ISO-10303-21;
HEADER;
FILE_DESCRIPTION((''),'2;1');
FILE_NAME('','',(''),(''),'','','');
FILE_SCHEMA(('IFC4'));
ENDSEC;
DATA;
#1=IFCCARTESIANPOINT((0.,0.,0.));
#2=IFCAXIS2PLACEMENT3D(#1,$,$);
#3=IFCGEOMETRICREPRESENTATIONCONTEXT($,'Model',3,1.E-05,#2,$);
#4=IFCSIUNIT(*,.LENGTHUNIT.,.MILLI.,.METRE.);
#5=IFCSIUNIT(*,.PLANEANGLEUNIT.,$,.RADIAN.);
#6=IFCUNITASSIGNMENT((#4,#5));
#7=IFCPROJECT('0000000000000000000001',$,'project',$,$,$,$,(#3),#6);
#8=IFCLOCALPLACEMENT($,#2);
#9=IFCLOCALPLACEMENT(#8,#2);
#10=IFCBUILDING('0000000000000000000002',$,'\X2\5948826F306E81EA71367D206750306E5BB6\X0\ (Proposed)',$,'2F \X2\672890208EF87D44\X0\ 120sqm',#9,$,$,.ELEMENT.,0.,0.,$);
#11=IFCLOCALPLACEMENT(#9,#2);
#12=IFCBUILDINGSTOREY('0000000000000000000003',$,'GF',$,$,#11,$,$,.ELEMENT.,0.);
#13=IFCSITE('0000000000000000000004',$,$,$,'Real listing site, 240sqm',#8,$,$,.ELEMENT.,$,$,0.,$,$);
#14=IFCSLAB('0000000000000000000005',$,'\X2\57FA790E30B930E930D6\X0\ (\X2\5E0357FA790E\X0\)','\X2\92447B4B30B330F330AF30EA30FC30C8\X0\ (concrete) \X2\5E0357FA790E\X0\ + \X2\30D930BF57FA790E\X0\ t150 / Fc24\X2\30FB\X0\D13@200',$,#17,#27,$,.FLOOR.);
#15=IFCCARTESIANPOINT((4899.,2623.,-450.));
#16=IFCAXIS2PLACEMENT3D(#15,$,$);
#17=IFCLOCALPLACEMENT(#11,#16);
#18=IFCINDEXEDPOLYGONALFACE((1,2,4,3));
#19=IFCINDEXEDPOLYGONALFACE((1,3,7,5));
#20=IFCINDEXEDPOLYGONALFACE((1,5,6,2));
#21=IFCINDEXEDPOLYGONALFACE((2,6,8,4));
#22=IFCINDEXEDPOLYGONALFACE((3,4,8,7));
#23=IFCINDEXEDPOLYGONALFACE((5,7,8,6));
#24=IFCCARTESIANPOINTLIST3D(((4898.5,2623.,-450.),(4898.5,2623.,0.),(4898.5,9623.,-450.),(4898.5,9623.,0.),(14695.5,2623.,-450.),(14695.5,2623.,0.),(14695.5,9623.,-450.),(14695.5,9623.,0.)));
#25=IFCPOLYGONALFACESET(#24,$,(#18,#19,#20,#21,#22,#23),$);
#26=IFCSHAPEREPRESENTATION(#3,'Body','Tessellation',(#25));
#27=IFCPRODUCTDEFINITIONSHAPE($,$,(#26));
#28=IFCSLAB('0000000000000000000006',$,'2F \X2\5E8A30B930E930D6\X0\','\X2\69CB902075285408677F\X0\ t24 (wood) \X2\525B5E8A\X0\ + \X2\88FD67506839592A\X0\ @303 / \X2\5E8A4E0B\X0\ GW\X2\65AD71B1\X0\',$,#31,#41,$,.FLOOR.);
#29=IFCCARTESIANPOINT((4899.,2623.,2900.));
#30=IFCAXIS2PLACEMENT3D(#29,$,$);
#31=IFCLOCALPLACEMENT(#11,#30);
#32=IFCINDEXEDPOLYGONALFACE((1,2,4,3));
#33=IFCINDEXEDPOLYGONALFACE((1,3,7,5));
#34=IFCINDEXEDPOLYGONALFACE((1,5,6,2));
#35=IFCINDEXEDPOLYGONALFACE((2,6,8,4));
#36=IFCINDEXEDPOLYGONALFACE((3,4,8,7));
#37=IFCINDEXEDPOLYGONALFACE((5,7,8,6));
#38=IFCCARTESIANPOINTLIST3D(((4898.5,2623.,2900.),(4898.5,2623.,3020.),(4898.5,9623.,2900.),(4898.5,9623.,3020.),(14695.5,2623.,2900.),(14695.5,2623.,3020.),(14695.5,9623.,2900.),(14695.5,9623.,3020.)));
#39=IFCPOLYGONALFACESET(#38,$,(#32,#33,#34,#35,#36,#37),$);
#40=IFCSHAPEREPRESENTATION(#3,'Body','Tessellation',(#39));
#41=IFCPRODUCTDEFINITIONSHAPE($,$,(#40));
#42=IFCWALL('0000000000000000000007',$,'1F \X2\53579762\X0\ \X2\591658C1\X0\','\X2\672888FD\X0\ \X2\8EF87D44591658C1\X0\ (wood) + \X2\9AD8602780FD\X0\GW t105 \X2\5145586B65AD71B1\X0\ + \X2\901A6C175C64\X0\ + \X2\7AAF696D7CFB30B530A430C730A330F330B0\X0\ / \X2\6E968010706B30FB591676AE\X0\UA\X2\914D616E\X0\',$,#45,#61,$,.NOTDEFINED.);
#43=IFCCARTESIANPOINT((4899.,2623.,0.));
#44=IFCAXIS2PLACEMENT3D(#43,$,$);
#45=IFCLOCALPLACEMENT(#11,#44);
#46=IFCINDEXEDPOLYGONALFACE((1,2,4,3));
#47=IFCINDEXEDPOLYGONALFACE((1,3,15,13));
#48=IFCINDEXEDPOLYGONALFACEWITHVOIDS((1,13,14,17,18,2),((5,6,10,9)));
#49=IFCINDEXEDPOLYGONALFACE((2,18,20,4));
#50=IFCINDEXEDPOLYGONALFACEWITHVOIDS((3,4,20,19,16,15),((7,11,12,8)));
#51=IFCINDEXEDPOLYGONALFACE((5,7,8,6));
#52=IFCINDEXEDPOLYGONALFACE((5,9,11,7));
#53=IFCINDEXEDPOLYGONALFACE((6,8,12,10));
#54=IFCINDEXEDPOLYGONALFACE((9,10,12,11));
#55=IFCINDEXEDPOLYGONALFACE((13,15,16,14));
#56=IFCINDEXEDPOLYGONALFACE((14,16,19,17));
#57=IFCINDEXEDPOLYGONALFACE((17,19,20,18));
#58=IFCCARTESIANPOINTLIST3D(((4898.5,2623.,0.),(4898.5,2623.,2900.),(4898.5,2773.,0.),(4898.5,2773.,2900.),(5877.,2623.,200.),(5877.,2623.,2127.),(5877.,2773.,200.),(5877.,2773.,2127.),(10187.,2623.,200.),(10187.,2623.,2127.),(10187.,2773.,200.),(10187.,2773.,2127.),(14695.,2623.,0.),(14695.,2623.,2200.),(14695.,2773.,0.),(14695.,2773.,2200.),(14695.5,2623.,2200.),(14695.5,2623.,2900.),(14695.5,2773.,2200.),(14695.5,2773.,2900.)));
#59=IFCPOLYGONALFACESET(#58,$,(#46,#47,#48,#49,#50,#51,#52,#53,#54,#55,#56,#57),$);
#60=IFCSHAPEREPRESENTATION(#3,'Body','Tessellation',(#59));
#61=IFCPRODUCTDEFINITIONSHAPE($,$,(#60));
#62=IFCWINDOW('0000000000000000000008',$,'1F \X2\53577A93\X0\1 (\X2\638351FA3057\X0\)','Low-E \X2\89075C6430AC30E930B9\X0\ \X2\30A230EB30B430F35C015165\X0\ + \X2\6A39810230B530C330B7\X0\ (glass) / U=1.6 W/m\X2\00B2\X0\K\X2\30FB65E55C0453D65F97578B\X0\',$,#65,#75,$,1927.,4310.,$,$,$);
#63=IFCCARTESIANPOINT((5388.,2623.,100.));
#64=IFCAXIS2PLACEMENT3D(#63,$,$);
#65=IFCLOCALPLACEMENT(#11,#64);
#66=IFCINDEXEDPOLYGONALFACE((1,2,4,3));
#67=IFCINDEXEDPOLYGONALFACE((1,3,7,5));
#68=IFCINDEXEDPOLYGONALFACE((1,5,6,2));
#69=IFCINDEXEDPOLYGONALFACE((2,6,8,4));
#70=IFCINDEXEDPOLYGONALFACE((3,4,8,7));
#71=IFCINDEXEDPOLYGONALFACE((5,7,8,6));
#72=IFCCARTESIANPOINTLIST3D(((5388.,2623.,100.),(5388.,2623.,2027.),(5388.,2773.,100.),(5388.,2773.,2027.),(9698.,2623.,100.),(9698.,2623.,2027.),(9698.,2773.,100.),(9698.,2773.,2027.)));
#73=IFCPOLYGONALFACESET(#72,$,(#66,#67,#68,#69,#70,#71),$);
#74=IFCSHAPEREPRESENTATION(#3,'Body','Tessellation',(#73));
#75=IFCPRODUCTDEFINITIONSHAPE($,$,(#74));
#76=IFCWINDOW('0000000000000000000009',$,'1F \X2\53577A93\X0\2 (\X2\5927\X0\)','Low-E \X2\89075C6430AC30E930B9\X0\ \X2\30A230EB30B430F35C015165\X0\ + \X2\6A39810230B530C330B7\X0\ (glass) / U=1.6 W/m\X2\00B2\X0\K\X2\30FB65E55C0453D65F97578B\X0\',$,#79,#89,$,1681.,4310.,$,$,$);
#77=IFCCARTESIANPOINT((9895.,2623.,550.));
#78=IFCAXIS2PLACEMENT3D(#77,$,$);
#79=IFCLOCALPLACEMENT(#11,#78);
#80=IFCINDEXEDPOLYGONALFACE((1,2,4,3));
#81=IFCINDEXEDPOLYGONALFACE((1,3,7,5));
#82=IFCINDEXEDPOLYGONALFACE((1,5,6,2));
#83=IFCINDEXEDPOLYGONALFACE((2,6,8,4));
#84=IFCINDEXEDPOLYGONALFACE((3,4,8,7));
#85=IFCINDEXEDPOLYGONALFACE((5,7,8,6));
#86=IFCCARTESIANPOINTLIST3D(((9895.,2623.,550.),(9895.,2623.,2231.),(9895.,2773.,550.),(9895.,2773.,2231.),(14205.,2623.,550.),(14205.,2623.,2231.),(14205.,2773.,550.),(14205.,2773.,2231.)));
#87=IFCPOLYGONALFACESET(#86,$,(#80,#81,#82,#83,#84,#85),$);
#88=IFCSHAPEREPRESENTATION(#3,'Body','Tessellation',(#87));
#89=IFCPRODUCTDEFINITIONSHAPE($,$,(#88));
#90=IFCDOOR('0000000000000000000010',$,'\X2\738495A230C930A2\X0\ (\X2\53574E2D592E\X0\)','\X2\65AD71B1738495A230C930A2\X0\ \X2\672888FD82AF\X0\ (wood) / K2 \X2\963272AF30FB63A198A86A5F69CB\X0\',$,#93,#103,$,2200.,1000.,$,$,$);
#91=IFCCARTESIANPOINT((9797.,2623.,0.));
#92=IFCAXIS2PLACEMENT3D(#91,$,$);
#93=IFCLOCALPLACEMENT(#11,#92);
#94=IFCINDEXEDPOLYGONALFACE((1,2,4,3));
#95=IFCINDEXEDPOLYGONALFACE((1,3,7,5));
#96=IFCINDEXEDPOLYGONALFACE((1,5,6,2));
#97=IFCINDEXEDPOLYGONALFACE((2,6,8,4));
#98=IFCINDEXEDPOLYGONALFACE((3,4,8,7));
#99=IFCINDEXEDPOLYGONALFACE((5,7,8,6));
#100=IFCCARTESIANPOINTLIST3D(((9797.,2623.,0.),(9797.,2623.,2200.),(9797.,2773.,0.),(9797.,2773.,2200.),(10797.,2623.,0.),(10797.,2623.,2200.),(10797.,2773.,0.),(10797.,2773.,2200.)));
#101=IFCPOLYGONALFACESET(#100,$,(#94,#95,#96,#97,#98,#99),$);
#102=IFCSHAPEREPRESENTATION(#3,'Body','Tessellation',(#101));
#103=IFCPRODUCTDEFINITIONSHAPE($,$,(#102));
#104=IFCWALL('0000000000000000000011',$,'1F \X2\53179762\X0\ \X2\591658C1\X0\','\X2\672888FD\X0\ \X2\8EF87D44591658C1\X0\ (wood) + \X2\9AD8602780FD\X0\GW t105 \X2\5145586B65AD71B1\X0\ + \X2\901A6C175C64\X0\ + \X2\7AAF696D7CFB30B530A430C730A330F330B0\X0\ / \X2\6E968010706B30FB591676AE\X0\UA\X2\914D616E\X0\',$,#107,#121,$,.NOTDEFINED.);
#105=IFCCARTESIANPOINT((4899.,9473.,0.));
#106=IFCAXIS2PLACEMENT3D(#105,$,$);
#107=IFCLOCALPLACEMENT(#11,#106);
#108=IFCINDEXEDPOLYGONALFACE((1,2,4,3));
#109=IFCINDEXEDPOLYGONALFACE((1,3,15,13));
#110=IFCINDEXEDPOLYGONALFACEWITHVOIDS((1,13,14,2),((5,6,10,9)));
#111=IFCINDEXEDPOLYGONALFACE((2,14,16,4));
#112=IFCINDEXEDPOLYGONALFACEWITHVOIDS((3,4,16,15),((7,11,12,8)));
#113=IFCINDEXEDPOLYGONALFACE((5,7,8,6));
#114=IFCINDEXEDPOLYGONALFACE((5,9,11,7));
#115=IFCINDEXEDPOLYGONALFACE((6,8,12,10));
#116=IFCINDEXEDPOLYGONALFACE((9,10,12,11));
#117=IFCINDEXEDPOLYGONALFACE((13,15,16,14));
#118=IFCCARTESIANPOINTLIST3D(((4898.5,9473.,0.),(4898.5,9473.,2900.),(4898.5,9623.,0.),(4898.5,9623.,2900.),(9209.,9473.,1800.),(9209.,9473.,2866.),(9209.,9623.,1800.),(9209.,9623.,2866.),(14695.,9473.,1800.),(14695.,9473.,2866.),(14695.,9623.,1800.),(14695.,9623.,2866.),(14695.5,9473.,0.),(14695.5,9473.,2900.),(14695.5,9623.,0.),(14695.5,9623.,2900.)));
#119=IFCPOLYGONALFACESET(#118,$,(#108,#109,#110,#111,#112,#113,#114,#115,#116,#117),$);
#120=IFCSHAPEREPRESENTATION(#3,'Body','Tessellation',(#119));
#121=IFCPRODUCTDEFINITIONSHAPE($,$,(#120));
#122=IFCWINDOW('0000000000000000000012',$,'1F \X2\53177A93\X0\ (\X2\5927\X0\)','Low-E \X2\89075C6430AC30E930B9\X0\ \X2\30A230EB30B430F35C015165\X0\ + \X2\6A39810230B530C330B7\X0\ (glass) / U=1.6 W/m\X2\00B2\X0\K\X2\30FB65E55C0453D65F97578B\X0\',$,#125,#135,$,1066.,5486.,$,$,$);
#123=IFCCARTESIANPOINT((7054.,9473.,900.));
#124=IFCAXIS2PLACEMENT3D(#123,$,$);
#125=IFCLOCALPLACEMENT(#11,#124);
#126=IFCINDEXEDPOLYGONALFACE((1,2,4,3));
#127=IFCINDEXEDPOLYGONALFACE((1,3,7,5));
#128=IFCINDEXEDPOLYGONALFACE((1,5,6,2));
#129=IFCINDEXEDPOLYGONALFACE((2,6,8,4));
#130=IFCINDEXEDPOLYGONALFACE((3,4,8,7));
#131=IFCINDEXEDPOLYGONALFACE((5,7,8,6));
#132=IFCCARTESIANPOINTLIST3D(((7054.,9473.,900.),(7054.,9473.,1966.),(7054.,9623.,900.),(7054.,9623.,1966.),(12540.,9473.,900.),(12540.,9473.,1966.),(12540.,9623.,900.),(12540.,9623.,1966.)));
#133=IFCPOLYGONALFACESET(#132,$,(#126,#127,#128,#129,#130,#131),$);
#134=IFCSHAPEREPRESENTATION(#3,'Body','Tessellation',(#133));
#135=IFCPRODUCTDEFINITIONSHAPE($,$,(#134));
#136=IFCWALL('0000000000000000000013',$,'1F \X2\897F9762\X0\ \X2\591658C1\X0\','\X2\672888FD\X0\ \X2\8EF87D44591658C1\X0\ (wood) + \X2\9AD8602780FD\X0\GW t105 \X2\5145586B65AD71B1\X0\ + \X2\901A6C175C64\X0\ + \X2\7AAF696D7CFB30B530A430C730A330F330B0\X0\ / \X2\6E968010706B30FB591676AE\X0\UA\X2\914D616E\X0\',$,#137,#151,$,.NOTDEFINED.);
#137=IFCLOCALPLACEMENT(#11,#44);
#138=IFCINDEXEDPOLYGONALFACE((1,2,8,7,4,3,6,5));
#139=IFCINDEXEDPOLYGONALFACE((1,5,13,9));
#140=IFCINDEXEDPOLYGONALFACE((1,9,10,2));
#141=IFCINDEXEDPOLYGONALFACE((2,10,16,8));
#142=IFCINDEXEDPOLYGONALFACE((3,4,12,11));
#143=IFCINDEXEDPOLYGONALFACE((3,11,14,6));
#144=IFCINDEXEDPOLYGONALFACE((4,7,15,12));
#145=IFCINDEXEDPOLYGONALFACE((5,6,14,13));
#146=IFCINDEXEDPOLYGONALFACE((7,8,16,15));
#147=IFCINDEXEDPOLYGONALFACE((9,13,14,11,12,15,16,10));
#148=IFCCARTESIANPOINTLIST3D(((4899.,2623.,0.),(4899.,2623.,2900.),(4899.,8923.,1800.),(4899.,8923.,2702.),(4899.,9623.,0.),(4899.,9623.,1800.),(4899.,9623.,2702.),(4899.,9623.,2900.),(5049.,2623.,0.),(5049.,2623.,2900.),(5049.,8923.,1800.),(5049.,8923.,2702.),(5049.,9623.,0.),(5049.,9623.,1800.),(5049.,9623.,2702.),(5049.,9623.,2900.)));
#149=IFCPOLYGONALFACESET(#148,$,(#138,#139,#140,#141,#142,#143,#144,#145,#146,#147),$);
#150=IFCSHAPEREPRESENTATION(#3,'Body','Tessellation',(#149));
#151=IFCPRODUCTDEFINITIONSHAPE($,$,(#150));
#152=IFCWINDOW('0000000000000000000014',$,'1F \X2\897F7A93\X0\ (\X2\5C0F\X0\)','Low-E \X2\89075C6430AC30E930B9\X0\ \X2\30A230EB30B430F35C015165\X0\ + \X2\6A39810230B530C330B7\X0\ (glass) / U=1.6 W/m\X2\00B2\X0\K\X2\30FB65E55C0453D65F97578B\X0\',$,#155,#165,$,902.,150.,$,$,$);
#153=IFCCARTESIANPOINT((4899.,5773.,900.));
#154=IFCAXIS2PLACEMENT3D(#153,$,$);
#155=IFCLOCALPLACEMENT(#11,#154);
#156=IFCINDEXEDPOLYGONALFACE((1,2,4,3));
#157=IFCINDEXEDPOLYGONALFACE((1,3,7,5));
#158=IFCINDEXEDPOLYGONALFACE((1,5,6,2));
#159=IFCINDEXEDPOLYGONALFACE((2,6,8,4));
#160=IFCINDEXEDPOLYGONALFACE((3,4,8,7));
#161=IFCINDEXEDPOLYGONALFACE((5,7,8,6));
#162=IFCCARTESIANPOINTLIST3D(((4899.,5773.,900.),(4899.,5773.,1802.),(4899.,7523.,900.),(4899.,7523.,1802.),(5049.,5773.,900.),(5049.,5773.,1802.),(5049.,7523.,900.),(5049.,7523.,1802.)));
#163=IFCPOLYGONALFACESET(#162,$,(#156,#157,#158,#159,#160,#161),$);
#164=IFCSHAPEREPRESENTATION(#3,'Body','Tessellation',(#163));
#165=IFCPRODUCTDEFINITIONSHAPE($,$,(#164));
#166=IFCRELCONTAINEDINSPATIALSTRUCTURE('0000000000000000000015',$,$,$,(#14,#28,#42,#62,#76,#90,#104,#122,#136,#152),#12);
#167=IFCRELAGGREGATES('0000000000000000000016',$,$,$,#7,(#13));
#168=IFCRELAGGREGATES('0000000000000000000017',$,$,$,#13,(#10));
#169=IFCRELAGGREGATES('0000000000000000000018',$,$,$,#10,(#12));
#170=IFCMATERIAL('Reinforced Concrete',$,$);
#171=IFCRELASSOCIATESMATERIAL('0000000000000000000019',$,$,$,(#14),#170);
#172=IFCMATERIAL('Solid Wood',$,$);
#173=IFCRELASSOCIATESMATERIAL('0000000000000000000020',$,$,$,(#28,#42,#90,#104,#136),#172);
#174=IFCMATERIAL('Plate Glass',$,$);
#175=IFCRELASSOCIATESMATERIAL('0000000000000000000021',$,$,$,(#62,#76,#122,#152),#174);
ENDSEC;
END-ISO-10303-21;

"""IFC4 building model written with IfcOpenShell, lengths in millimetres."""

from ifc_helpers import new_model, si_unit, frame, frame_2d, origin, place, context, project, spatial, rectangle, extrude, material, element, fill, save


model = new_model("IFC4")

# Units and contexts
model_context = context("Model", 3, precision=1e-05, world=origin())
ifc_project = project(units=[si_unit("LENGTHUNIT", "METRE", prefix="MILLI"), si_unit("PLANEANGLEUNIT", "RADIAN")], contexts=[model_context])

# Site, building, storey
site_placement = place(None, origin())
site = spatial("IfcSite", under=ifc_project, at=site_placement, ObjectType="Real listing site, 240sqm", CompositionType="ELEMENT", RefElevation=0.0)
building_placement = place(site_placement, origin())
building = spatial("IfcBuilding", under=site, at=building_placement, Name="奈良の自然素材の家 (Proposed)", ObjectType="2F 木造軸組 120sqm", CompositionType="ELEMENT", ElevationOfRefHeight=0.0, ElevationOfTerrain=0.0)
storey_placement = place(building_placement, origin())
storey = spatial("IfcBuildingStorey", under=building, at=storey_placement, Name="GF", CompositionType="ELEMENT", Elevation=0.0)

# Slabs
ifc_material_1 = material(Name="Reinforced Concrete")
slab_1_placement = place(storey_placement, frame((4899.0, 2623.0, -450.0)))
element("IfcSlab", 1, at=slab_1_placement, inside=storey, material=ifc_material_1, Name="基礎スラブ (布基礎)", Description="鉄筋コンクリート (concrete) 布基礎 + ベタ基礎 t150 / Fc24・D13@200", PredefinedType="FLOOR", context=model_context, shape_type="SweptSolid", body=[
    extrude(rectangle(XDim=9797.0, YDim=7000.0, at=frame_2d((4898.0, 3500.0))), frame((4899.0, 2623.0, -450.0)), (0.0, 0.0, 1.0), 450.0),
])
ifc_material_2 = material(Name="Solid Wood")
slab_2_placement = place(storey_placement, frame((4899.0, 2623.0, 2900.0)))
element("IfcSlab", 2, at=slab_2_placement, inside=storey, material=ifc_material_2, Name="2F 床スラブ", Description="構造用合板 t24 (wood) 剛床 + 製材根太 @303 / 床下 GW断熱", PredefinedType="FLOOR", context=model_context, shape_type="SweptSolid", body=[
    extrude(rectangle(XDim=9797.0, YDim=7000.0, at=frame_2d((4898.0, 3500.0))), frame((4899.0, 2623.0, 2900.0)), (0.0, 0.0, 1.0), 120.0),
])

# Wall, openings, windows, door
wall_1_placement = place(storey_placement, frame((4899.0, 2623.0, 0.0)))
wall_1 = element("IfcWall", 3, at=wall_1_placement, inside=storey, material=ifc_material_2, Name="1F 南面 外壁", Description="木製 軸組外壁 (wood) + 高性能GW t105 充填断熱 + 通気層 + 窯業系サイディング / 準耐火・外皮UA配慮", PredefinedType="NOTDEFINED", context=model_context, shape_type="SweptSolid", body=[
    extrude(rectangle(XDim=9797.0, YDim=150.0, at=frame_2d((4898.0, 75.0))), frame((4899.0, 2623.0, 0.0)), (0.0, 0.0, 1.0), 2900.0),
])
opening_1_placement = place(storey_placement, frame((5388.0, 2623.0, 100.0)))
opening_1 = element("IfcOpeningElement", 4, at=opening_1_placement, cuts=wall_1, PredefinedType="NOTDEFINED", context=model_context, shape_type="SweptSolid", body=[
    extrude(rectangle(XDim=4310.0, YDim=150.0, at=frame_2d((2155.0, 75.0))), frame((5388.0, 2623.0, 100.0)), (0.0, 0.0, 1.0), 1927.0),
])
opening_2_placement = place(storey_placement, frame((9895.0, 2623.0, 550.0)))
opening_2 = element("IfcOpeningElement", 5, at=opening_2_placement, cuts=wall_1, PredefinedType="NOTDEFINED", context=model_context, shape_type="SweptSolid", body=[
    extrude(rectangle(XDim=4310.0, YDim=150.0, at=frame_2d((2155.0, 75.0))), frame((9895.0, 2623.0, 550.0)), (0.0, 0.0, 1.0), 1681.0),
])
opening_3_placement = place(storey_placement, frame((9797.0, 2623.0, 0.0)))
opening_3 = element("IfcOpeningElement", 6, at=opening_3_placement, cuts=wall_1, PredefinedType="NOTDEFINED", context=model_context, shape_type="SweptSolid", body=[
    extrude(rectangle(XDim=1000.0, YDim=150.0, at=frame_2d((500.0, 75.0))), frame((9797.0, 2623.0, 0.0)), (0.0, 0.0, 1.0), 2200.0),
])
ifc_material_3 = material(Name="Plate Glass")
window_1_placement = place(storey_placement, frame((5388.0, 2623.0, 100.0)))
window_1 = element("IfcWindow", 7, at=window_1_placement, inside=storey, material=ifc_material_3, Name="1F 南窓1 (掃出し)", Description="Low-E 複層ガラス アルゴン封入 + 樹脂サッシ (glass) / U=1.6 W/m²K・日射取得型", OverallHeight=1927.0, OverallWidth=4310.0, context=model_context, shape_type="SweptSolid", body=[
    extrude(rectangle(XDim=4310.0, YDim=150.0, at=frame_2d((2155.0, 75.0))), frame((5388.0, 2623.0, 100.0)), (0.0, 0.0, 1.0), 1927.0),
])
fill(opening_1, window_1)
window_2_placement = place(storey_placement, frame((9895.0, 2623.0, 550.0)))
window_2 = element("IfcWindow", 8, at=window_2_placement, inside=storey, material=ifc_material_3, Name="1F 南窓2 (大)", Description="Low-E 複層ガラス アルゴン封入 + 樹脂サッシ (glass) / U=1.6 W/m²K・日射取得型", OverallHeight=1681.0, OverallWidth=4310.0, context=model_context, shape_type="SweptSolid", body=[
    extrude(rectangle(XDim=4310.0, YDim=150.0, at=frame_2d((2155.0, 75.0))), frame((9895.0, 2623.0, 550.0)), (0.0, 0.0, 1.0), 1681.0),
])
fill(opening_2, window_2)
door_placement = place(storey_placement, frame((9797.0, 2623.0, 0.0)))
door = element("IfcDoor", 9, at=door_placement, inside=storey, material=ifc_material_2, Name="玄関ドア (南中央)", Description="断熱玄関ドア 木製芯 (wood) / K2 防犯・採風機構", OverallHeight=2200.0, OverallWidth=1000.0, context=model_context, shape_type="SweptSolid", body=[
    extrude(rectangle(XDim=1000.0, YDim=150.0, at=frame_2d((500.0, 75.0))), frame((9797.0, 2623.0, 0.0)), (0.0, 0.0, 1.0), 2200.0),
])
fill(opening_3, door)

# Walls, openings, windows
wall_2_placement = place(storey_placement, frame((4899.0, 9473.0, 0.0)))
wall_2 = element("IfcWall", 10, at=wall_2_placement, inside=storey, material=ifc_material_2, Name="1F 北面 外壁", Description="木製 軸組外壁 (wood) + 高性能GW t105 充填断熱 + 通気層 + 窯業系サイディング / 準耐火・外皮UA配慮", PredefinedType="NOTDEFINED", context=model_context, shape_type="SweptSolid", body=[
    extrude(rectangle(XDim=9797.0, YDim=150.0, at=frame_2d((4898.0, 75.0))), frame((4899.0, 9473.0, 0.0)), (0.0, 0.0, 1.0), 2900.0),
])
opening_4_placement = place(storey_placement, frame((7054.0, 9473.0, 900.0)))
opening_4 = element("IfcOpeningElement", 11, at=opening_4_placement, cuts=wall_2, PredefinedType="NOTDEFINED", context=model_context, shape_type="SweptSolid", body=[
    extrude(rectangle(XDim=5486.0, YDim=150.0, at=frame_2d((2743.0, 75.0))), frame((7054.0, 9473.0, 900.0)), (0.0, 0.0, 1.0), 1066.0),
])
window_3_placement = place(storey_placement, frame((7054.0, 9473.0, 900.0)))
window_3 = element("IfcWindow", 12, at=window_3_placement, inside=storey, material=ifc_material_3, Name="1F 北窓 (大)", Description="Low-E 複層ガラス アルゴン封入 + 樹脂サッシ (glass) / U=1.6 W/m²K・日射取得型", OverallHeight=1066.0, OverallWidth=5486.0, context=model_context, shape_type="SweptSolid", body=[
    extrude(rectangle(XDim=5486.0, YDim=150.0, at=frame_2d((2743.0, 75.0))), frame((7054.0, 9473.0, 900.0)), (0.0, 0.0, 1.0), 1066.0),
])
fill(opening_4, window_3)
wall_3_placement = place(storey_placement, frame((4899.0, 2623.0, 0.0)))
wall_3 = element("IfcWall", 13, at=wall_3_placement, inside=storey, material=ifc_material_2, Name="1F 西面 外壁", Description="木製 軸組外壁 (wood) + 高性能GW t105 充填断熱 + 通気層 + 窯業系サイディング / 準耐火・外皮UA配慮", PredefinedType="NOTDEFINED", context=model_context, shape_type="SweptSolid", body=[
    extrude(rectangle(XDim=150.0, YDim=7000.0, at=frame_2d((75.0, 3500.0))), frame((4899.0, 2623.0, 0.0)), (0.0, 0.0, 1.0), 2900.0),
])
opening_5_placement = place(storey_placement, frame((4899.0, 5773.0, 900.0)))
opening_5 = element("IfcOpeningElement", 14, at=opening_5_placement, cuts=wall_3, PredefinedType="NOTDEFINED", context=model_context, shape_type="SweptSolid", body=[
    extrude(rectangle(XDim=150.0, YDim=1750.0, at=frame_2d((75.0, 875.0))), frame((4899.0, 5773.0, 900.0)), (0.0, 0.0, 1.0), 902.0),
])
window_4_placement = place(storey_placement, frame((4899.0, 5773.0, 900.0)))
window_4 = element("IfcWindow", 15, at=window_4_placement, inside=storey, material=ifc_material_3, Name="1F 西窓 (小)", Description="Low-E 複層ガラス アルゴン封入 + 樹脂サッシ (glass) / U=1.6 W/m²K・日射取得型", OverallHeight=902.0, OverallWidth=150.0, context=model_context, shape_type="SweptSolid", body=[
    extrude(rectangle(XDim=150.0, YDim=1750.0, at=frame_2d((75.0, 875.0))), frame((4899.0, 5773.0, 900.0)), (0.0, 0.0, 1.0), 902.0),
])
fill(opening_5, window_4)

save(model, "model.ifc")
